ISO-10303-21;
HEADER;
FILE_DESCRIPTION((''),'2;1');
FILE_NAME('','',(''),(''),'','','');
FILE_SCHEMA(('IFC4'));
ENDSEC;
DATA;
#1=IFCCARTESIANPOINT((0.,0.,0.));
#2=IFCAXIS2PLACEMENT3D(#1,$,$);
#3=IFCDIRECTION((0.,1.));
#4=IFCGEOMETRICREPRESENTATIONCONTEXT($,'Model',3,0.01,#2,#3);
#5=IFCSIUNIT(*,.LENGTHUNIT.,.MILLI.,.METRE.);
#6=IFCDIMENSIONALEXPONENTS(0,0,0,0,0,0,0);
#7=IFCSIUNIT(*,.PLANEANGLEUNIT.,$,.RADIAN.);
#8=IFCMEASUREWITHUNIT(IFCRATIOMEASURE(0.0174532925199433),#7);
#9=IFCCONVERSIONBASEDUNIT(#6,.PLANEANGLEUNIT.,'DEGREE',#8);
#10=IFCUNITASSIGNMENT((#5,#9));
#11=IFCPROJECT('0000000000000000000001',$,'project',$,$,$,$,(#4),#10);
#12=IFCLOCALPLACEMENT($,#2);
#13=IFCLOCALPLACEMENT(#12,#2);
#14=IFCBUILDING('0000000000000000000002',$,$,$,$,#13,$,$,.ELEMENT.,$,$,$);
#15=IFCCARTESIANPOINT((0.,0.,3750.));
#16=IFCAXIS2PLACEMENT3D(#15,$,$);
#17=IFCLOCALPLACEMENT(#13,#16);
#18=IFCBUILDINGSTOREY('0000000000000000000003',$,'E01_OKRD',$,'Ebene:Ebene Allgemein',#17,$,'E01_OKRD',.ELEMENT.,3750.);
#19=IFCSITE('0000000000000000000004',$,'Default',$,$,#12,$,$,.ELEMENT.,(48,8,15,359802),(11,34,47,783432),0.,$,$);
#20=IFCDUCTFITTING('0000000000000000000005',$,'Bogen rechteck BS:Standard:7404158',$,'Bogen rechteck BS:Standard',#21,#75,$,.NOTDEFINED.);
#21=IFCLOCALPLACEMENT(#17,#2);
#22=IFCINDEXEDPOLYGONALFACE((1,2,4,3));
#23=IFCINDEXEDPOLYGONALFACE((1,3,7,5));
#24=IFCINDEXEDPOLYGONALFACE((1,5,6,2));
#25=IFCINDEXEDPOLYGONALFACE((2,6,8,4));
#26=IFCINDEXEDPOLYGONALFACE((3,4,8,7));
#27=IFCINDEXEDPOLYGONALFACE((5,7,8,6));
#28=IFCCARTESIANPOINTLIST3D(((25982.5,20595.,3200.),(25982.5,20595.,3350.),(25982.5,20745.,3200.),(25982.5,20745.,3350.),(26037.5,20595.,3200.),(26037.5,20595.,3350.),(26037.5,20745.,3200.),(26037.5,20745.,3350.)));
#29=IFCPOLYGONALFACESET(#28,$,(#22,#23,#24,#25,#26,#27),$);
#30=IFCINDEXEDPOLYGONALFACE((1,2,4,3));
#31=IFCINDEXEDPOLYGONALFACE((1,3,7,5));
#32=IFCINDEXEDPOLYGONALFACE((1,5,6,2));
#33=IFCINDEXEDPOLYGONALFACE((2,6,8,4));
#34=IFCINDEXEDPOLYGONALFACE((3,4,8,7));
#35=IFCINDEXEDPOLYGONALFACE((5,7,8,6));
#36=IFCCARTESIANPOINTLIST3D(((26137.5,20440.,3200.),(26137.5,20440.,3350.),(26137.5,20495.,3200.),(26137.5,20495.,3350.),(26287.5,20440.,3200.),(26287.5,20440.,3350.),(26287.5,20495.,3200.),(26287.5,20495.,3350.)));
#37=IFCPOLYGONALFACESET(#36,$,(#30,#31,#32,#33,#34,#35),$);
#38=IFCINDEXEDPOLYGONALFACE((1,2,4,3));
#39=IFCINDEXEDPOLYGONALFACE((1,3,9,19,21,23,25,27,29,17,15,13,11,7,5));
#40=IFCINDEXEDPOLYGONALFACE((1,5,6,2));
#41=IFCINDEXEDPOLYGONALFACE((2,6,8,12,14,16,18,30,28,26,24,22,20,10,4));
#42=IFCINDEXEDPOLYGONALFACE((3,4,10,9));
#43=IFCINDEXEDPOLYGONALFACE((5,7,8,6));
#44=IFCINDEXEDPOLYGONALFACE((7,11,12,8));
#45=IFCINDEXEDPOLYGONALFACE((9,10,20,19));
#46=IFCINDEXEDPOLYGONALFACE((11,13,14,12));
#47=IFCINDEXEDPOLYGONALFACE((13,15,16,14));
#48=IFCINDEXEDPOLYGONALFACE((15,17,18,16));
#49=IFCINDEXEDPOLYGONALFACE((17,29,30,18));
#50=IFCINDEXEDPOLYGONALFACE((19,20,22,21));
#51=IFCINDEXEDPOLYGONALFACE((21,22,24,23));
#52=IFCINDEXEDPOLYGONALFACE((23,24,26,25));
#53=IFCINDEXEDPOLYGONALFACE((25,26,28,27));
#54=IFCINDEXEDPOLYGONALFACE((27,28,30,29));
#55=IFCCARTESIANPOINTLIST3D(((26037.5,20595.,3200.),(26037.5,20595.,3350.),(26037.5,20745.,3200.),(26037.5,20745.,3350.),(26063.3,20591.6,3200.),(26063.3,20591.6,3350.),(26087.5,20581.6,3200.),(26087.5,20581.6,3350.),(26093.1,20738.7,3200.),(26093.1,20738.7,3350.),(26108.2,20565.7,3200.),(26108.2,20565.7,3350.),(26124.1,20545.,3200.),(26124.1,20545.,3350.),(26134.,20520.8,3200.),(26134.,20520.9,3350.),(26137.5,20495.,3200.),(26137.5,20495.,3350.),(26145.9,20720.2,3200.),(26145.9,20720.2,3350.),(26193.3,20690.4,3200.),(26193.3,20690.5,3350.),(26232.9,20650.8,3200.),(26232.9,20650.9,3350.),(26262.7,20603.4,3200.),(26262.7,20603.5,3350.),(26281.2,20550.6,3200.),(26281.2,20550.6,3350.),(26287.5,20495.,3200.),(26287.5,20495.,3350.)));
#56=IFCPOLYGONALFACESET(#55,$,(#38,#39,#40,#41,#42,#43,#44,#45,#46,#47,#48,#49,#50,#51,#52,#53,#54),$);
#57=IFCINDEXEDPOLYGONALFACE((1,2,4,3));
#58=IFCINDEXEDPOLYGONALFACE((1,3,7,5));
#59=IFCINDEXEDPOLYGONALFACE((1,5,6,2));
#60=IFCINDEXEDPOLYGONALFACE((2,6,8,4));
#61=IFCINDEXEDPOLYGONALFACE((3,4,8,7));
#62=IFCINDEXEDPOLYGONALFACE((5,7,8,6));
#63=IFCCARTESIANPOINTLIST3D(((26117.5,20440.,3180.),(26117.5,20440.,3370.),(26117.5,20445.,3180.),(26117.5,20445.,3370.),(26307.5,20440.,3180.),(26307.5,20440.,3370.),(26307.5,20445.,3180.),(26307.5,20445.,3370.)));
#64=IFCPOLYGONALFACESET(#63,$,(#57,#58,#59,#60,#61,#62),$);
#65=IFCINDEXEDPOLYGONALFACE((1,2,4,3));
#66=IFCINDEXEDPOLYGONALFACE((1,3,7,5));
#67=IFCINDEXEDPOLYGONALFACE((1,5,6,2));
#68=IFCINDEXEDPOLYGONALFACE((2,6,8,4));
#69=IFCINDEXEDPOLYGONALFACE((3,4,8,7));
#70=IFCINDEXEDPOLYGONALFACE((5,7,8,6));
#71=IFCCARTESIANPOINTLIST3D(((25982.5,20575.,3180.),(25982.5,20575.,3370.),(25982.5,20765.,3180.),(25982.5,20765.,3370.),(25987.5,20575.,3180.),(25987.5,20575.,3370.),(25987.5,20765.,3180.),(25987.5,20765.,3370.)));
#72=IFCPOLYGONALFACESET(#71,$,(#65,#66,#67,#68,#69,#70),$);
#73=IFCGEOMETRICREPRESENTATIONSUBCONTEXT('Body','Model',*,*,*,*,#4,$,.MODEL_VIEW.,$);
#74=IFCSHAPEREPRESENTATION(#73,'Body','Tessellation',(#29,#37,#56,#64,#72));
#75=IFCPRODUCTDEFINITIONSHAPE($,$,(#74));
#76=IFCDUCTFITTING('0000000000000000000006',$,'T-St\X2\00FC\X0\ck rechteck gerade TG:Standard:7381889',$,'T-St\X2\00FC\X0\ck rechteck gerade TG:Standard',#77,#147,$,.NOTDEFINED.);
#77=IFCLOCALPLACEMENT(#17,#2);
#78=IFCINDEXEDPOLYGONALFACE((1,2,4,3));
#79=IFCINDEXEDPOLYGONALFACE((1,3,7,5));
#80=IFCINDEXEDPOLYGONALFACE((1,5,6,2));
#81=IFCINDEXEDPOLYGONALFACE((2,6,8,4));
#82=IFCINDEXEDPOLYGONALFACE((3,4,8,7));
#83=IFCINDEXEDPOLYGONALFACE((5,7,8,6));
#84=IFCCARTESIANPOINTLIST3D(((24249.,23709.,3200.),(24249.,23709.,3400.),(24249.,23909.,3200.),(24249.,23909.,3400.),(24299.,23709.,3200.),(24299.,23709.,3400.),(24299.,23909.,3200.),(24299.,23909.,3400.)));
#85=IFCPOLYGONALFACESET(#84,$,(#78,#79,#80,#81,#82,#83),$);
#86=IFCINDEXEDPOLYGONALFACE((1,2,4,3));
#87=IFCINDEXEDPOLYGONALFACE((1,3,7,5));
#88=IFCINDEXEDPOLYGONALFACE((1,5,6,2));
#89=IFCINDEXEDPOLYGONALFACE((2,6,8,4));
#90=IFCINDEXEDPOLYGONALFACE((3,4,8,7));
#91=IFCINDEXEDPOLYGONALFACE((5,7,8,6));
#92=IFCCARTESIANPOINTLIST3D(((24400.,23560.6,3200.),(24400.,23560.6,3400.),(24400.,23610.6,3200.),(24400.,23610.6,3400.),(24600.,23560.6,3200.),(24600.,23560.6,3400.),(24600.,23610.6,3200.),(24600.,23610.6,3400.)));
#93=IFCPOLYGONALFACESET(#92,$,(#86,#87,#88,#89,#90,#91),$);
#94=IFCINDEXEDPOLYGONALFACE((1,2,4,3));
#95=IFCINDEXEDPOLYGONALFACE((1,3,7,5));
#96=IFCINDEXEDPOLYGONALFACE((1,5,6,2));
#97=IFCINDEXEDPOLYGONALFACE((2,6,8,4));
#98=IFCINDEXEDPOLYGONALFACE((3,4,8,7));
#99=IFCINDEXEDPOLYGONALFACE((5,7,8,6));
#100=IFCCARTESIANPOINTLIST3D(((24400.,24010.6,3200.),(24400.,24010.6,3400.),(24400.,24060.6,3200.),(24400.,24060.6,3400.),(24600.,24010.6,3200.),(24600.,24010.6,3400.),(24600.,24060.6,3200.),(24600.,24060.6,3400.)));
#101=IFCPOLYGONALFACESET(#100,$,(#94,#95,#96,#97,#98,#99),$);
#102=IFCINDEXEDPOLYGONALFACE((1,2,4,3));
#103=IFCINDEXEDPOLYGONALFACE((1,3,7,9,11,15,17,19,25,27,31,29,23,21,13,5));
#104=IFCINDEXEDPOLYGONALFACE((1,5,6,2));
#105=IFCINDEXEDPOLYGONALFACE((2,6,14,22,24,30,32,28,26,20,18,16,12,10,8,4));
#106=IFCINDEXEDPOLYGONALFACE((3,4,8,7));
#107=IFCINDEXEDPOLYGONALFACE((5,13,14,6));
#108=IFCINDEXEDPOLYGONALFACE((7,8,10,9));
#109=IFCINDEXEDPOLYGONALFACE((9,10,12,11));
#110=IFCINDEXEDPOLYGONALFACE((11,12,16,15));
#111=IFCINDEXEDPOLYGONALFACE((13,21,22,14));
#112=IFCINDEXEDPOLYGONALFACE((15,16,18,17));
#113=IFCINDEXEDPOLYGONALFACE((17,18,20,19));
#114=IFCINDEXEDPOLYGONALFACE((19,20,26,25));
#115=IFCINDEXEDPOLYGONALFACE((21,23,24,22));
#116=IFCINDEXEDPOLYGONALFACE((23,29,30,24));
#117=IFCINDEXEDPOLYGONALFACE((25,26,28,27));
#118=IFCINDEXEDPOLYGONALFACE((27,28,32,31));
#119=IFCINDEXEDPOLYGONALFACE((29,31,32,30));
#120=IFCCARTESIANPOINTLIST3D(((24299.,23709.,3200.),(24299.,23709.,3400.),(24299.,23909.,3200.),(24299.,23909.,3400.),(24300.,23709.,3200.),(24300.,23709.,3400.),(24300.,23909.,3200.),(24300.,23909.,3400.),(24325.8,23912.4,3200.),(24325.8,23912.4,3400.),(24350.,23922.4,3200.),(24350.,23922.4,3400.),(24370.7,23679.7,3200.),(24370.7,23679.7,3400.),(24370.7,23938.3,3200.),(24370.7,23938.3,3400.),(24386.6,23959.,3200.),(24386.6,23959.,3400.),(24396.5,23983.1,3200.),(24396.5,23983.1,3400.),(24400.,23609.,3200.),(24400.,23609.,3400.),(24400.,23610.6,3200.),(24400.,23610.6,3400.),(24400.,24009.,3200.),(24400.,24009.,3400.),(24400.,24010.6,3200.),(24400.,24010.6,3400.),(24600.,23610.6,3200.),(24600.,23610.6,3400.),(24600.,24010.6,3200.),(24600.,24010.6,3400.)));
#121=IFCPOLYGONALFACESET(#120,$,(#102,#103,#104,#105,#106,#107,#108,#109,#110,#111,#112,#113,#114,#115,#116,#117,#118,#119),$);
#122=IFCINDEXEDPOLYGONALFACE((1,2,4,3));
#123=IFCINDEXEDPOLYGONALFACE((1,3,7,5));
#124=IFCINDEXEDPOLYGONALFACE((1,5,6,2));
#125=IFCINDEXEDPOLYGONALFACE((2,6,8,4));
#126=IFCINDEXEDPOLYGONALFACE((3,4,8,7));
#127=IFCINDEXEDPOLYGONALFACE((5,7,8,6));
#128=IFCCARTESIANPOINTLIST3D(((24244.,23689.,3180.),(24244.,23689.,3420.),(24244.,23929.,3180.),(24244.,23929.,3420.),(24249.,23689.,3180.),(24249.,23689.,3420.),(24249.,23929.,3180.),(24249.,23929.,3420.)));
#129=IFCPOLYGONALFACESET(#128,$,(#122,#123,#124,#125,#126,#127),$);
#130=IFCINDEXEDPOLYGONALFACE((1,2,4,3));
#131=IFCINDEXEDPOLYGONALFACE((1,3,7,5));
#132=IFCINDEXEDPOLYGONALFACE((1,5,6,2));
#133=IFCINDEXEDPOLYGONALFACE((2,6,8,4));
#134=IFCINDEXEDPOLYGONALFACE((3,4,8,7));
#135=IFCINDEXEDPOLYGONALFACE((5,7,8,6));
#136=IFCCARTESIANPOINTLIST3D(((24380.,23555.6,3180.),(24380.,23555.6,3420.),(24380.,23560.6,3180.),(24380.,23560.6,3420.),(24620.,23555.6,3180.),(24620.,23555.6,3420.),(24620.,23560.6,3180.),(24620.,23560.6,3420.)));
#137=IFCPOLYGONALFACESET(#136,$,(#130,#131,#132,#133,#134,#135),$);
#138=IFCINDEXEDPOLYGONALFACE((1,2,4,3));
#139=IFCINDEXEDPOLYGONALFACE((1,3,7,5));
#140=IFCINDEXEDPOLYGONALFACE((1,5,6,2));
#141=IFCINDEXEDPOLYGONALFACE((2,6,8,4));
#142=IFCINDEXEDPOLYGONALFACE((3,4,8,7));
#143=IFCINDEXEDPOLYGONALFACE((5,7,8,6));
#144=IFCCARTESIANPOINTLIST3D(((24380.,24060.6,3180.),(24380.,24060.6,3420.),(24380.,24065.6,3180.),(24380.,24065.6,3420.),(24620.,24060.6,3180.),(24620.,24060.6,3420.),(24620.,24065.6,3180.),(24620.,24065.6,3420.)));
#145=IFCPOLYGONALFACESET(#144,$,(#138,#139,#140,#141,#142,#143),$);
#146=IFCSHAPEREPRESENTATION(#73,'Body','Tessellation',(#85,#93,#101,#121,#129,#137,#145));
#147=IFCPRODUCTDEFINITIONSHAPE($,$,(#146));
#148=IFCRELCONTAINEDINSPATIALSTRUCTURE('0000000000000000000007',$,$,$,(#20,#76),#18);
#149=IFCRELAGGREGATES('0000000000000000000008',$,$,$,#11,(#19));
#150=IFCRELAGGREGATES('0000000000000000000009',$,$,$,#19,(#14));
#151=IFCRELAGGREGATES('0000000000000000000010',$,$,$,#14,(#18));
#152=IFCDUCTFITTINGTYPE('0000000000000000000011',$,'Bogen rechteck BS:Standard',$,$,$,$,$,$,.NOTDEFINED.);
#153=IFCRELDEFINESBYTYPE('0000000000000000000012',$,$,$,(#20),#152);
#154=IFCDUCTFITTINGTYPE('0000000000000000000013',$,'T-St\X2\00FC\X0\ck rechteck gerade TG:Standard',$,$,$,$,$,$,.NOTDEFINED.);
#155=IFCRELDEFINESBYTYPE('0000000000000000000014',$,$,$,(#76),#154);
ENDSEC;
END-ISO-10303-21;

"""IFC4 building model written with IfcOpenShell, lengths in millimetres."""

from ifc_helpers import new_model, entity, si_unit, converted_unit, direction, frame, frame_2d, origin, origin_2d_with_axis, place, context, subcontext, project, spatial, polyline, circle_curve, parameter, trimmed, segment, composite_curve, rectangle, outline, extrude, source, transform, mapped, type_object, type_shapes, element, save


model = new_model("IFC4")

# Units and contexts
model_context = context("Model", 3, precision=0.01, world=origin(), true_north=direction((0.0, 1.0)))
body_context = subcontext(model_context, "Body", "Model", "MODEL_VIEW")
ifc_project = project(units=[si_unit("LENGTHUNIT", "METRE", prefix="MILLI"), converted_unit("PLANEANGLEUNIT", "DEGREE", entity("IfcRatioMeasure", 0.0174532925199433), si_unit("PLANEANGLEUNIT", "RADIAN"), dimensions=[0, 0, 0, 0, 0, 0, 0])], contexts=[model_context])

# Site, building, storey
site_placement = place(None, origin())
site = spatial("IfcSite", under=ifc_project, at=site_placement, Name="Default", CompositionType="ELEMENT", RefLatitude=(48, 8, 15, 359802), RefLongitude=(11, 34, 47, 783432), RefElevation=0.0)
building_placement = place(site_placement, origin())
building = spatial("IfcBuilding", under=site, at=building_placement, CompositionType="ELEMENT")
storey_placement = place(building_placement, frame((0.0, 0.0, 3750.0)))
storey = spatial("IfcBuildingStorey", under=building, at=storey_placement, Name="E01_OKRD", ObjectType="Ebene:Ebene Allgemein", LongName="E01_OKRD", CompositionType="ELEMENT", Elevation=3750.0)

# Duct fittings
duct_fitting_type_1 = type_object("IfcDuctFittingType", Name="Bogen rechteck BS:Standard", PredefinedType="NOTDEFINED")
shared_shape_1 = source(origin(), body_context, "Body", "SweptSolid", [
    extrude(rectangle(XDim=55.0, YDim=150.0, at=origin_2d_with_axis()), frame((0.0, 202.5, -75.0), z_axis=(0.0, 0.0, 1.0), x_axis=(0.0, 1.0, 0.0)), (0.0, 0.0, 1.0), 150.0),
    extrude(rectangle(XDim=150.0, YDim=55.0, at=frame_2d((0.0, 0.0), x_axis=(1.0, 0.0))), frame((-202.5, 0.0, -75.0), z_axis=(0.0, 0.0, 1.0), x_axis=(0.0, -1.0, 0.0)), (0.0, 0.0, 1.0), 150.0),
    extrude(outline(composite_curve([segment(polyline([(-162.5, -87.5), (-12.5, -87.5)]), True, "CONTINUOUS"), segment(trimmed(circle_curve(frame_2d((87.5, -87.5), x_axis=(0.0, 1.0)), 100.0), [parameter(0.0)], [parameter(90.0)], True, "PARAMETER"), False, "CONTINUOUS"), segment(polyline([(87.5, 12.5), (87.5, 162.5)]), True, "CONTINUOUS"), segment(trimmed(circle_curve(frame_2d((87.5, -87.5), x_axis=(0.0, 1.0)), 250.0), [parameter(0.0)], [parameter(90.0)], True, "PARAMETER"), True, "CONTINUOUS")], self_intersect=False)), frame((-87.5, 87.5, -75.0), z_axis=(0.0, 0.0, 1.0), x_axis=(-1.0, 0.0, 0.0)), (0.0, 0.0, 1.0), 150.0),
    extrude(rectangle(XDim=5.0, YDim=190.0, at=frame_2d((0.0, 0.0), x_axis=(1.0, 0.0))), frame((-227.5, 0.0, -95.0)), (0.0, 0.0, 1.0), 190.0),
    extrude(rectangle(XDim=5.0, YDim=190.0, at=frame_2d((0.0, 0.0), x_axis=(1.0, 0.0))), frame((0.0, 227.5, -95.0), z_axis=(0.0, 0.0, 1.0), x_axis=(0.0, 1.0, 0.0)), (0.0, 0.0, 1.0), 190.0),
])
type_shapes(duct_fitting_type_1, [shared_shape_1])
for number, where, z_axis, x_axis, name in (
    (1, (26212.5, 20670.0, 3275.0), (0.0, 0.0002, 1.0), (0.0, 1.0, -0.0002), "Bogen rechteck BS:Standard:7404158"),
):
    element("IfcDuctFitting", number, at=place(storey_placement, frame(where, z_axis=z_axis, x_axis=x_axis)), inside=storey, type_object=duct_fitting_type_1, Name=name, ObjectType="Bogen rechteck BS:Standard", PredefinedType="NOTDEFINED", context=body_context, shape_type="MappedRepresentation", body=[
        mapped(shared_shape_1, transform((0.0, 0.0, 0.0), scale=1.0)),
    ])
duct_fitting_type_2 = type_object("IfcDuctFittingType", Name="T-Stück rechteck gerade TG:Standard", PredefinedType="NOTDEFINED")
shared_shape_2 = source(origin(), body_context, "Body", "SweptSolid", [
    extrude(rectangle(XDim=50.0, YDim=200.0, at=frame_2d((0.0, 0.0), x_axis=(1.0, 0.0))), frame((0.0, -226.0, -100.0), z_axis=(0.0, 0.0, 1.0), x_axis=(0.0, -1.0, 0.0)), (0.0, 0.0, 1.0), 200.0),
    extrude(rectangle(XDim=50.0, YDim=200.0, at=frame_2d((0.0, 0.0), x_axis=(1.0, 0.0))), frame((223.4, 0.0, -100.0), z_axis=(0.0, 0.0, 1.0), x_axis=(-1.0, 0.0, 0.0)), (0.0, 0.0, 1.0), 200.0),
    extrude(rectangle(XDim=50.0, YDim=200.0, at=frame_2d((0.0, 0.0), x_axis=(1.0, 0.0))), frame((-226.6, 0.0, -100.0)), (0.0, 0.0, 1.0), 200.0),
    extrude(outline(composite_curve([segment(trimmed(circle_curve(frame_2d((-200.6, -99.8), x_axis=(-1.0, 0.0)), 100.0), [parameter(180.0)], [parameter(270.0)], True, "PARAMETER"), False, "CONTINUOUS"), segment(polyline([(-100.6, -99.8), (-100.6, -100.8)]), True, "CONTINUOUS"), segment(polyline([(-100.6, -100.8), (99.4, -100.8)]), True, "CONTINUOUS"), segment(polyline([(99.4, -100.8), (99.4, -99.8)]), True, "CONTINUOUS"), segment(trimmed(circle_curve(frame_2d((199.4, -99.8), x_axis=(-1.0, 0.0)), 100.0), [parameter(270.0)], [parameter(0.0)], True, "PARAMETER"), False, "CONTINUOUS"), segment(polyline([(199.4, 0.2), (201.0, 0.2)]), True, "CONTINUOUS"), segment(polyline([(201.0, 0.2), (201.0, 200.2)]), True, "CONTINUOUS"), segment(polyline([(201.0, 200.2), (-199.0, 200.2)]), True, "CONTINUOUS"), segment(polyline([(-199.0, 200.2), (-199.0, 0.2)]), True, "CONTINUOUS"), segment(polyline([(-199.0, 0.2), (-200.6, 0.2)]), True, "CONTINUOUS")], self_intersect=False)), frame((-0.6, -100.2, -100.0), z_axis=(0.0, 0.0, -1.0), x_axis=(-1.0, 0.0, 0.0)), (0.0, 0.0, -1.0), 200.0),
    extrude(rectangle(XDim=5.0, YDim=240.0, at=frame_2d((0.0, 0.0), x_axis=(1.0, 0.0))), frame((0.0, -253.5, -120.0), z_axis=(0.0, 0.0, 1.0), x_axis=(0.0, 1.0, 0.0)), (0.0, 0.0, 1.0), 240.0),
    extrude(rectangle(XDim=5.0, YDim=240.0, at=origin_2d_with_axis()), frame((250.9, 0.0, -120.0), z_axis=(0.0, 0.0, 1.0), x_axis=(-1.0, 0.0, 0.0)), (0.0, 0.0, 1.0), 240.0),
    extrude(rectangle(XDim=5.0, YDim=240.0, at=origin_2d_with_axis()), frame((-254.1, 0.0, -120.0), z_axis=(0.0, 0.0, 1.0), x_axis=(-1.0, 0.0, 0.0)), (0.0, 0.0, 1.0), 240.0),
])
type_shapes(duct_fitting_type_2, [shared_shape_2])
duct_fitting_placement = place(storey_placement, frame((24500.0, 23809.0, 3300.0), z_axis=(0.0, 0.0, 1.0), x_axis=(0.0, -1.0, 0.0)))
element("IfcDuctFitting", 2, at=duct_fitting_placement, inside=storey, type_object=duct_fitting_type_2, Name="T-Stück rechteck gerade TG:Standard:7381889", ObjectType="T-Stück rechteck gerade TG:Standard", PredefinedType="NOTDEFINED", context=body_context, shape_type="MappedRepresentation", body=[
    mapped(shared_shape_2, transform((0.0, 0.0, 0.0), scale=1.0)),
])

save(model, "model.ifc")
